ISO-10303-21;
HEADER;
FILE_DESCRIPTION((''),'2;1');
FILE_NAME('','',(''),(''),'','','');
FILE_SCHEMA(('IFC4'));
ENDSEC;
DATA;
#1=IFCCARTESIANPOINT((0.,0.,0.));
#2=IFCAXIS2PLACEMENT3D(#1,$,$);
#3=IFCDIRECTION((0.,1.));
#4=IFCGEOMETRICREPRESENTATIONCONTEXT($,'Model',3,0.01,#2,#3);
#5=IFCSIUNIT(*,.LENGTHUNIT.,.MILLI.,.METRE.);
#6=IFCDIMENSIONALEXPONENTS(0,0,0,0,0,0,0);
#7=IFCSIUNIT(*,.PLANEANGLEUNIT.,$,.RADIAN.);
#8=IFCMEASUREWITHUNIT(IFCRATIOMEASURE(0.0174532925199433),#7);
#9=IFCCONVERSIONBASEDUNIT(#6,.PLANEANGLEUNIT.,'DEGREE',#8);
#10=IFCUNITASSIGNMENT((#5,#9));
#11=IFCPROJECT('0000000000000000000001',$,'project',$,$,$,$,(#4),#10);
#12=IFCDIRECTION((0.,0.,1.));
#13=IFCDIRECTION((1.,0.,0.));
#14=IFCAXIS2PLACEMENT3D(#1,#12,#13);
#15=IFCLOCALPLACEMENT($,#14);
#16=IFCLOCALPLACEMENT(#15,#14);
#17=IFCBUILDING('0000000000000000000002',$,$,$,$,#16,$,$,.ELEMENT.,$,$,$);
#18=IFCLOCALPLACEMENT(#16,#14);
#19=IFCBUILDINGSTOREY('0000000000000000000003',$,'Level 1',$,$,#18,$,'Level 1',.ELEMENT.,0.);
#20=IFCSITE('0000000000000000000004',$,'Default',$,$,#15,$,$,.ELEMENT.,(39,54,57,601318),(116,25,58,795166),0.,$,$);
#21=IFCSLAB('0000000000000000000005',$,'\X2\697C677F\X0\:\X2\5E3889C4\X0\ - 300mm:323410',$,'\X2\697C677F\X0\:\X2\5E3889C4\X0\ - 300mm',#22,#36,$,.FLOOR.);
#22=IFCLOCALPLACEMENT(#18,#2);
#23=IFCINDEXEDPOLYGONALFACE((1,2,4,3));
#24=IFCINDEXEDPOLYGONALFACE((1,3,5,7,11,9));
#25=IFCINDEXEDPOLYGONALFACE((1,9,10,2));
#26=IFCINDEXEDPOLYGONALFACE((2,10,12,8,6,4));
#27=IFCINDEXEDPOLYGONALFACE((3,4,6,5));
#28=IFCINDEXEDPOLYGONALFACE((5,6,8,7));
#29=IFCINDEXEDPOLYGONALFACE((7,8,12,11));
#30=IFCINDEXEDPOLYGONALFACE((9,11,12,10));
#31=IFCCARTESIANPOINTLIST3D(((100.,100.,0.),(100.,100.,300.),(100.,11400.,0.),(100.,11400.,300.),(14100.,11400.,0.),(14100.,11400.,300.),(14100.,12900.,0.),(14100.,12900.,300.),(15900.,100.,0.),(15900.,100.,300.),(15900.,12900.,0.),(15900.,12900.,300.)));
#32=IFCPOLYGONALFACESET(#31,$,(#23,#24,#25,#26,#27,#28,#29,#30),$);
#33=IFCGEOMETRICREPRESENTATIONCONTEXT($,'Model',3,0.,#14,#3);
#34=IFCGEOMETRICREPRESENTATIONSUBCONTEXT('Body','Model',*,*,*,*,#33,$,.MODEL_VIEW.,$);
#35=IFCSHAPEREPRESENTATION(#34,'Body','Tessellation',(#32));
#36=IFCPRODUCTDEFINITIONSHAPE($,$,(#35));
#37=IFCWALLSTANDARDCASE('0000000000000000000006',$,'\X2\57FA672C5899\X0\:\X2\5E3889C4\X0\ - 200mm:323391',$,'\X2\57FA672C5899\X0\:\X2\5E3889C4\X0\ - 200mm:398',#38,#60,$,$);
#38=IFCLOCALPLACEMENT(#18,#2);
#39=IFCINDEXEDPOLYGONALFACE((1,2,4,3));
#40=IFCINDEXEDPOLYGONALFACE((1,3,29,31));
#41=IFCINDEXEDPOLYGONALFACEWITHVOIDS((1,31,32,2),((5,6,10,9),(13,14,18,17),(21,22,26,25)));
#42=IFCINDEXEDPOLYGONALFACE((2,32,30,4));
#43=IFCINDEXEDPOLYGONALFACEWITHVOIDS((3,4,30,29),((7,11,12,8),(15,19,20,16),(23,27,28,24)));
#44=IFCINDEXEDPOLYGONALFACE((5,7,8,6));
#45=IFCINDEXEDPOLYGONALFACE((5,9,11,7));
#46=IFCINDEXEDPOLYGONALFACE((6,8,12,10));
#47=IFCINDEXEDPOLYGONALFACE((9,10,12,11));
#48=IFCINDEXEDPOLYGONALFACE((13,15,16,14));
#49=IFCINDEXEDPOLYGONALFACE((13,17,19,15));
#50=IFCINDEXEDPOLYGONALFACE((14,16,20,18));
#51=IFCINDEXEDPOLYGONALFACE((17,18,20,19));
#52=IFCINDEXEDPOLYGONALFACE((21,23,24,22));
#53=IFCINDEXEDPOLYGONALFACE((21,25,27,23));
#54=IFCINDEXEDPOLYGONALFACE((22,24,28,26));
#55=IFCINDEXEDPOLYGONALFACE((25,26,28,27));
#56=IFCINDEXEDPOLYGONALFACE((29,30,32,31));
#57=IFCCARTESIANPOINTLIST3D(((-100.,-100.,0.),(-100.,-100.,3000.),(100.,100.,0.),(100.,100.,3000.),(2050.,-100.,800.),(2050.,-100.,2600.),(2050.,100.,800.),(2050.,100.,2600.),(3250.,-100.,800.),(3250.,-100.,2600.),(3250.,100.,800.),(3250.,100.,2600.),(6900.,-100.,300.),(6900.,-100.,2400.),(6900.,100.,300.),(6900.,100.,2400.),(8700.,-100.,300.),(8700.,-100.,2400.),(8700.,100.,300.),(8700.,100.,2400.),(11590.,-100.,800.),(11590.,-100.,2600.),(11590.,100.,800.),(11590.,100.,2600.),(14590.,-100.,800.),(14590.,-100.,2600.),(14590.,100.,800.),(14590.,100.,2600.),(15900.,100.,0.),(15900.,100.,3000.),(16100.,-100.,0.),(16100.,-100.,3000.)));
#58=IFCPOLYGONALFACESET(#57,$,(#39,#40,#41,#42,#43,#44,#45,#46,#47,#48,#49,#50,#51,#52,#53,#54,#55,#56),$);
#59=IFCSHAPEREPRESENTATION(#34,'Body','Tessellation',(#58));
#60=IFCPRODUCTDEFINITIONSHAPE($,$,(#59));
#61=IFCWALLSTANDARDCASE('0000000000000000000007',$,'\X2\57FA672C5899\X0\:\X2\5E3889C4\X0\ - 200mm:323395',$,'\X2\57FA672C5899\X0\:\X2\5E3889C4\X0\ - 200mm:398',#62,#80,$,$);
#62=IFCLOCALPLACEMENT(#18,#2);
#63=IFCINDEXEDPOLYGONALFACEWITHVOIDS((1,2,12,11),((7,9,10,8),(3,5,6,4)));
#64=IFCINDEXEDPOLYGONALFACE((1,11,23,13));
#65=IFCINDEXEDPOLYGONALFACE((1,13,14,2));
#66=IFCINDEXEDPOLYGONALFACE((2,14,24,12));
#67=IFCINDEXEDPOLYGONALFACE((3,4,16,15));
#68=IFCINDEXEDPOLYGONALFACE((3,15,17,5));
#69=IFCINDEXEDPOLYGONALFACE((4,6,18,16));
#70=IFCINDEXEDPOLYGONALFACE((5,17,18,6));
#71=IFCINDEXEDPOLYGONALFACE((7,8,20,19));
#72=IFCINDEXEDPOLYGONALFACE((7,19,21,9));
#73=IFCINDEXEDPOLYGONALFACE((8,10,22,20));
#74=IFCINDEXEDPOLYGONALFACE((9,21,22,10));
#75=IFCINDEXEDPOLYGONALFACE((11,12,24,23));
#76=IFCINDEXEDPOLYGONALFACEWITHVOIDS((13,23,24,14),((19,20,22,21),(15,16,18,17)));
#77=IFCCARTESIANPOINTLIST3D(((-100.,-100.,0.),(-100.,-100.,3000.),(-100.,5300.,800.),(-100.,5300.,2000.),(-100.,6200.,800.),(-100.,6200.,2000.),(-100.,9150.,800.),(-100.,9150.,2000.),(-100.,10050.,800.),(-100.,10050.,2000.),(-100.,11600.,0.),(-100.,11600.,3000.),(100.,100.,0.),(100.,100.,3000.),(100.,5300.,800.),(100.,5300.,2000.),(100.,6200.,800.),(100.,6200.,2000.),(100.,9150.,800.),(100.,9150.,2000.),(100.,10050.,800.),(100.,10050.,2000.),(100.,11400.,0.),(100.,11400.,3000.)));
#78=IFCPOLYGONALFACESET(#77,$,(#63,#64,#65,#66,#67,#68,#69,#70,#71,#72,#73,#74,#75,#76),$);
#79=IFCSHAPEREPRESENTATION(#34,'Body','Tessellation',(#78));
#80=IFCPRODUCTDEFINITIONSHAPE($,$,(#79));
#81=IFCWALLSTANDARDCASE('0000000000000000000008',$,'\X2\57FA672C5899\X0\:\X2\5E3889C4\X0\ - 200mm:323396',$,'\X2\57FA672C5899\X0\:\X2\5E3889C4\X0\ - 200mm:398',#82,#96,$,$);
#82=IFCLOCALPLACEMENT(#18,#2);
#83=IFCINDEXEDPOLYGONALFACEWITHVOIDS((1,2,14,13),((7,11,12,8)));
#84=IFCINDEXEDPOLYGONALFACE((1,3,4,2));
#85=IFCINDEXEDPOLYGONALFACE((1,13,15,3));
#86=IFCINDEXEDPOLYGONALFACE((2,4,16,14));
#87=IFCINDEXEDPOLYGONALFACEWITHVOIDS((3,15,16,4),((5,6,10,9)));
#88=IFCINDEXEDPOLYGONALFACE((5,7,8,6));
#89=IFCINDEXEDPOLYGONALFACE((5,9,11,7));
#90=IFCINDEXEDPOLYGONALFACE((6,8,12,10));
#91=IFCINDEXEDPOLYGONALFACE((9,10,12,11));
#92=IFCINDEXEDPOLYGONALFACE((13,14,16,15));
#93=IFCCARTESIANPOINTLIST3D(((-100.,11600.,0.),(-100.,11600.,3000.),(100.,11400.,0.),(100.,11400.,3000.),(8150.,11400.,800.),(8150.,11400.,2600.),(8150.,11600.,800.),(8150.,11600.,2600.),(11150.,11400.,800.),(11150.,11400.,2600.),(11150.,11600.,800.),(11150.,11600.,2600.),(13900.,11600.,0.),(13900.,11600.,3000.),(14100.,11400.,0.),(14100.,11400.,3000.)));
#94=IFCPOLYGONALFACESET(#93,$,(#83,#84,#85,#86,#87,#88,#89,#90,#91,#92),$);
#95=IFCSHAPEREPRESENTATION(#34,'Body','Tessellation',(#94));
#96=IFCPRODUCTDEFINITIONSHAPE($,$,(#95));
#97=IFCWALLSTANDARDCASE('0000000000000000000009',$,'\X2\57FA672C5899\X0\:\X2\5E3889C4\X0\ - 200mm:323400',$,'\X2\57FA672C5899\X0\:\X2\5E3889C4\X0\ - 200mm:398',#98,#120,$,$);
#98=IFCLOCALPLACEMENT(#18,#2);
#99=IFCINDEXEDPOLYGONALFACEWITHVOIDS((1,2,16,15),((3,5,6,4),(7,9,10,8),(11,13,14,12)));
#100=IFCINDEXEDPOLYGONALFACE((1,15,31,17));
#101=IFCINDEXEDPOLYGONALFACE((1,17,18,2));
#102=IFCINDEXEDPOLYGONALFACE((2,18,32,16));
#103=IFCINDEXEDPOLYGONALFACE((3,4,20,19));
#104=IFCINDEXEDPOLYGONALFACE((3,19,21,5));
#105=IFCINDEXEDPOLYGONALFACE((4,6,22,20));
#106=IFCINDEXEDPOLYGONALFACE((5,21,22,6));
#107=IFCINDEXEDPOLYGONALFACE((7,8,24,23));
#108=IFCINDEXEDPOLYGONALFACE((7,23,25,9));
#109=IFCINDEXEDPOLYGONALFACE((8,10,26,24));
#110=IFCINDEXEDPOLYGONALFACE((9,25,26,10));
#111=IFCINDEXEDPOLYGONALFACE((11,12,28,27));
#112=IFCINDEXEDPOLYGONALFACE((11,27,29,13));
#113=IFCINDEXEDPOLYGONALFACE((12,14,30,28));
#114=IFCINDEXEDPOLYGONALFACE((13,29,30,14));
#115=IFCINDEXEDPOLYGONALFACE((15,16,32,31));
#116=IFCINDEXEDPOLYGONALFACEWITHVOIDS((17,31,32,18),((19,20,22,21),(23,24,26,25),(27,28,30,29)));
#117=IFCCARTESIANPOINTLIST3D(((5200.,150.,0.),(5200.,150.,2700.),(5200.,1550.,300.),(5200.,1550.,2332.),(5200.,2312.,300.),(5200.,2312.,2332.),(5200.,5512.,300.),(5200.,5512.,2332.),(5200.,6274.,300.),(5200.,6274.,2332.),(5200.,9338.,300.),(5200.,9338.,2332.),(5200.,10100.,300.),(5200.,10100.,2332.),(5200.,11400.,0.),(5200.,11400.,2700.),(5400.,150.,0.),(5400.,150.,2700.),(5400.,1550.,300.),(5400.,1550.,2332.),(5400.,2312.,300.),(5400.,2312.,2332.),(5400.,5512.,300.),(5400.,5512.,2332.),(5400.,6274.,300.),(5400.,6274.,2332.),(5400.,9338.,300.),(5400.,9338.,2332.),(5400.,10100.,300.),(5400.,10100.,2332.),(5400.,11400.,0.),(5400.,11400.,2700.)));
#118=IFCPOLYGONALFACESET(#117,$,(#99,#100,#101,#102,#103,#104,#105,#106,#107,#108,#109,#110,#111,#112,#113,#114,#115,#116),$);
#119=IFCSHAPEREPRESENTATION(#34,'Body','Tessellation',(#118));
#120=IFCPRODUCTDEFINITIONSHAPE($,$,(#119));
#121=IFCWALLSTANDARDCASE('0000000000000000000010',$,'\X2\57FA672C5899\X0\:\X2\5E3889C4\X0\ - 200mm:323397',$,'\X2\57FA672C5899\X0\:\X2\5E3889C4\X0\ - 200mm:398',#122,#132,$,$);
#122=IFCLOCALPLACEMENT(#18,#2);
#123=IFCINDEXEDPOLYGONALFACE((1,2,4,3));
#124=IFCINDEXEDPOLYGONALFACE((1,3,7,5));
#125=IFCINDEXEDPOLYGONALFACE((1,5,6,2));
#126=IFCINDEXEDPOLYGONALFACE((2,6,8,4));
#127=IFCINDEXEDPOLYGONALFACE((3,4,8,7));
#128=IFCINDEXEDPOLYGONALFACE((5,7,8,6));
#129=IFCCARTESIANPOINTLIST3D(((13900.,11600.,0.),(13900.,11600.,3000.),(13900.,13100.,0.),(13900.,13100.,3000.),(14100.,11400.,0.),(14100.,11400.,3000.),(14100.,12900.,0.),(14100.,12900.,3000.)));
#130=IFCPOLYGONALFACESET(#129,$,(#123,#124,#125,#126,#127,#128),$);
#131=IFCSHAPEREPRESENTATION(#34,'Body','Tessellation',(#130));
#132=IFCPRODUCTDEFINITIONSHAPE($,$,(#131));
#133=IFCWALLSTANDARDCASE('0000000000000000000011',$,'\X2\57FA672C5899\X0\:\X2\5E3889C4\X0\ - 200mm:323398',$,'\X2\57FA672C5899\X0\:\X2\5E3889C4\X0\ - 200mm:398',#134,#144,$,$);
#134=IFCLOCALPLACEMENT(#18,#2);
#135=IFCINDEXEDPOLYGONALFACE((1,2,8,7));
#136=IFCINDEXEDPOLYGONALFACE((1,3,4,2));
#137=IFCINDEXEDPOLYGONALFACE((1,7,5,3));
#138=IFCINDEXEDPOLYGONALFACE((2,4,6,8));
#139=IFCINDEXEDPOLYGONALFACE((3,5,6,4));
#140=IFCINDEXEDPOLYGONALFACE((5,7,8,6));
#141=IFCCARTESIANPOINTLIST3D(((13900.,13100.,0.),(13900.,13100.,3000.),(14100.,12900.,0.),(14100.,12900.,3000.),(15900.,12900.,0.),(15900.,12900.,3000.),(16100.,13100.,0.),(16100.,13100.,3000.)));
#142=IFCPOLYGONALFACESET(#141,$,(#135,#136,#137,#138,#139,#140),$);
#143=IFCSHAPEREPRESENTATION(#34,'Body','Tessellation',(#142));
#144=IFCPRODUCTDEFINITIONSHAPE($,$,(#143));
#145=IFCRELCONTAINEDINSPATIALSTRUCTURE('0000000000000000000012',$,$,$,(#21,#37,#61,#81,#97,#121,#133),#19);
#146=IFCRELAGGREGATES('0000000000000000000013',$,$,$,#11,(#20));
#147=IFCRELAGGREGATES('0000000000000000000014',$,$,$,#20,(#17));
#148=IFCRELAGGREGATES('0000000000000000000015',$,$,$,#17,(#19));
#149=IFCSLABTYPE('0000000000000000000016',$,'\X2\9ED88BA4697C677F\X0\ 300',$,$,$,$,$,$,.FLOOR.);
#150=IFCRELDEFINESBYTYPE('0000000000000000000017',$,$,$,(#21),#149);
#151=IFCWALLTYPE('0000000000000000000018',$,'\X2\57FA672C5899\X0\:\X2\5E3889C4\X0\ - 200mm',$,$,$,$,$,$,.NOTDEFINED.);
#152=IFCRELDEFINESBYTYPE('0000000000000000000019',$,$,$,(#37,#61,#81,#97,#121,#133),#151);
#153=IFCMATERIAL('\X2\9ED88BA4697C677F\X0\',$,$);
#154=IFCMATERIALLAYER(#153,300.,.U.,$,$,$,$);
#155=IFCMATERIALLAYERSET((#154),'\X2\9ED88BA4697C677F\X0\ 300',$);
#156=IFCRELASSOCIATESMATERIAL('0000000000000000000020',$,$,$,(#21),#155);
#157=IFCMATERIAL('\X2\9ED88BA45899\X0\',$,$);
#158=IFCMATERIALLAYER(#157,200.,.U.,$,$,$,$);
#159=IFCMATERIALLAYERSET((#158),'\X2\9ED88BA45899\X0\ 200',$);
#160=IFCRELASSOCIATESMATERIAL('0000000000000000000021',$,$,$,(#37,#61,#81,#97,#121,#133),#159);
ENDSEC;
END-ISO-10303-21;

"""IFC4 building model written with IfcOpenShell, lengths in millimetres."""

from ifc_helpers import new_model, entity, si_unit, converted_unit, direction, frame, origin, origin_with_axes, place, context, subcontext, project, spatial, polyline, outline, extrude, clip, halfspace, material, layer, layer_set, layer_usage, type_object, element, save


model = new_model("IFC4")

# Units and contexts
model_context_1 = context("Model", 3, precision=0.01, world=origin(), true_north=direction((0.0, 1.0)))
model_context_2 = context("Model", 3, precision=0.0, world=origin_with_axes(), true_north=direction((0.0, 1.0)))
body_context = subcontext(model_context_2, "Body", "Model", "MODEL_VIEW")
ifc_project = project(units=[si_unit("LENGTHUNIT", "METRE", prefix="MILLI"), converted_unit("PLANEANGLEUNIT", "DEGREE", entity("IfcRatioMeasure", 0.0174532925199433), si_unit("PLANEANGLEUNIT", "RADIAN"), dimensions=[0, 0, 0, 0, 0, 0, 0])], contexts=[model_context_1])

# Site, building, storey
site_placement = place(None, origin_with_axes())
site = spatial("IfcSite", under=ifc_project, at=site_placement, Name="Default", CompositionType="ELEMENT", RefLatitude=(39, 54, 57, 601318), RefLongitude=(116, 25, 58, 795166), RefElevation=0.0)
building_placement = place(site_placement, origin_with_axes())
building = spatial("IfcBuilding", under=site, at=building_placement, CompositionType="ELEMENT")
storey_placement = place(building_placement, origin_with_axes())
storey = spatial("IfcBuildingStorey", under=building, at=storey_placement, Name="Level 1", LongName="Level 1", CompositionType="ELEMENT", Elevation=0.0)

# Slab
ifc_material_1 = material(Name="默认楼板")
ifc_layer_1 = layer(ifc_material_1, 300.0, ventilated="UNKNOWN")
ifc_layer_set_1 = layer_set([ifc_layer_1], Name="默认楼板 300")
ifc_layer_usage_1 = layer_usage(ifc_layer_set_1, "AXIS3", "NEGATIVE", 300.0)
slab_type = type_object("IfcSlabType", Name="默认楼板 300", PredefinedType="FLOOR")
slab_placement = place(storey_placement, frame((100.0, 100.0, 0.0), z_axis=(0.0, 0.0, 1.0), x_axis=(1.0, 0.0, 0.0)))
element("IfcSlab", 1, at=slab_placement, inside=storey, type_object=slab_type, material=ifc_layer_usage_1, Name="楼板:常规 - 300mm:323410", ObjectType="楼板:常规 - 300mm", PredefinedType="FLOOR", context=body_context, shape_type="SweptSolid", body=[
    extrude(outline(polyline([(0.0, 0.0), (15800.0, 0.0), (15800.0, 12800.0), (14000.0, 12800.0), (14000.0, 11300.0), (0.0, 11300.0), (0.0, 0.0)])), origin_with_axes(), (0.0, 0.0, 1.0), 300.0),
])

# Walls, openings
ifc_material_2 = material(Name="默认墙")
ifc_layer_2 = layer(ifc_material_2, 200.0, ventilated="UNKNOWN")
ifc_layer_set_2 = layer_set([ifc_layer_2], Name="默认墙 200")
ifc_layer_usage_2 = layer_usage(ifc_layer_set_2, "AXIS2", "POSITIVE", -100.0)
wall_type = type_object("IfcWallType", Name="基本墙:常规 - 200mm", PredefinedType="NOTDEFINED")
wall_1_placement = place(storey_placement, frame((16000.0, 0.0, 0.0), z_axis=(0.0, 0.0, 1.0), x_axis=(-1.0, 0.0, 0.0)))
wall_1 = element("IfcWallStandardCase", 2, at=wall_1_placement, inside=storey, type_object=wall_type, material=ifc_layer_usage_2, Name="基本墙:常规 - 200mm:323391", ObjectType="基本墙:常规 - 200mm:398", context=body_context, shape_type="SweptSolid", body=[
    extrude(outline(polyline([(100.0, -100.0), (15900.0, -100.0), (16100.0, 100.0), (-100.0, 100.0), (100.0, -100.0)])), origin_with_axes(), (0.0, 0.0, 1.0), 3000.0),
])
opening_1_placement = place(wall_1_placement, frame((13350.0, 0.0, 800.0), z_axis=(0.0, 0.0, 1.0), x_axis=(1.0, 0.0, 0.0)))
element("IfcOpeningElement", 3, at=opening_1_placement, cuts=wall_1, context=body_context, shape_type="SweptSolid", body=[
    extrude(outline(polyline([(-600.0, 0.0), (-600.0, -1800.0), (600.0, -1800.0), (600.0, 0.0), (-600.0, 0.0)])), frame((0.0, -100.0, 0.0), z_axis=(0.0, 1.0, 0.0), x_axis=(1.0, 0.0, 0.0)), (0.0, 0.0, 1.0), 200.0),
])
opening_2_placement = place(wall_1_placement, frame((2910.0, 0.0, 800.0), z_axis=(0.0, 0.0, 1.0), x_axis=(1.0, 0.0, 0.0)))
element("IfcOpeningElement", 4, at=opening_2_placement, cuts=wall_1, context=body_context, shape_type="SweptSolid", body=[
    extrude(outline(polyline([(-1500.0, 0.0), (-1500.0, -1800.0), (1500.0, -1800.0), (1500.0, 0.0), (-1500.0, 0.0)])), frame((0.0, -100.0, 0.0), z_axis=(0.0, 1.0, 0.0), x_axis=(1.0, 0.0, 0.0)), (0.0, 0.0, 1.0), 200.0),
])
opening_3_placement = place(wall_1_placement, frame((8200.0, 0.0, 300.0), z_axis=(0.0, 0.0, 1.0), x_axis=(1.0, 0.0, 0.0)))
element("IfcOpeningElement", 5, at=opening_3_placement, cuts=wall_1, context=body_context, shape_type="SweptSolid", body=[
    extrude(outline(polyline([(-900.0, 0.0), (-900.0, -2100.0), (900.0, -2100.0), (900.0, 0.0), (-900.0, 0.0)])), frame((0.0, -100.0, 0.0), z_axis=(0.0, 1.0, 0.0), x_axis=(1.0, 0.0, 0.0)), (0.0, 0.0, 1.0), 200.0),
])
ifc_layer_usage_3 = layer_usage(ifc_layer_set_2, "AXIS2", "POSITIVE", -100.0)
wall_2_placement = place(storey_placement, frame((0.0, 0.0, 0.0), z_axis=(0.0, 0.0, 1.0), x_axis=(0.0, 1.0, 0.0)))
wall_2 = element("IfcWallStandardCase", 6, at=wall_2_placement, inside=storey, type_object=wall_type, material=ifc_layer_usage_3, Name="基本墙:常规 - 200mm:323395", ObjectType="基本墙:常规 - 200mm:398", context=body_context, shape_type="SweptSolid", body=[
    extrude(outline(polyline([(100.0, -100.0), (11400.0, -100.0), (11600.0, 100.0), (-100.0, 100.0), (100.0, -100.0)])), origin_with_axes(), (0.0, 0.0, 1.0), 3000.0),
])
opening_4_placement = place(wall_2_placement, frame((5750.0, 0.0, 800.0), z_axis=(0.0, 0.0, 1.0), x_axis=(1.0, 0.0, 0.0)))
element("IfcOpeningElement", 7, at=opening_4_placement, cuts=wall_2, context=body_context, shape_type="SweptSolid", body=[
    extrude(outline(polyline([(450.0, -1200.0), (450.0, 0.0), (-450.0, 0.0), (-450.0, -1200.0), (450.0, -1200.0)])), frame((0.0, 100.0, 0.0), z_axis=(0.0, -1.0, 0.0), x_axis=(-1.0, 0.0, 0.0)), (0.0, 0.0, 1.0), 200.0),
])
opening_5_placement = place(wall_2_placement, frame((9600.0, 0.0, 800.0), z_axis=(0.0, 0.0, 1.0), x_axis=(1.0, 0.0, 0.0)))
element("IfcOpeningElement", 8, at=opening_5_placement, cuts=wall_2, context=body_context, shape_type="SweptSolid", body=[
    extrude(outline(polyline([(450.0, -1200.0), (450.0, 0.0), (-450.0, 0.0), (-450.0, -1200.0), (450.0, -1200.0)])), frame((0.0, 100.0, 0.0), z_axis=(0.0, -1.0, 0.0), x_axis=(-1.0, 0.0, 0.0)), (0.0, 0.0, 1.0), 200.0),
])

# Wall, opening
ifc_layer_usage_4 = layer_usage(ifc_layer_set_2, "AXIS2", "POSITIVE", -100.0)
wall_3_placement = place(storey_placement, frame((0.0, 11500.0, 0.0), z_axis=(0.0, 0.0, 1.0), x_axis=(1.0, 0.0, 0.0)))
wall_3 = element("IfcWallStandardCase", 9, at=wall_3_placement, inside=storey, type_object=wall_type, material=ifc_layer_usage_4, Name="基本墙:常规 - 200mm:323396", ObjectType="基本墙:常规 - 200mm:398", context=body_context, shape_type="SweptSolid", body=[
    extrude(outline(polyline([(100.0, -100.0), (14100.0, -100.0), (13900.0, 100.0), (-100.0, 100.0), (100.0, -100.0)])), origin_with_axes(), (0.0, 0.0, 1.0), 3000.0),
])
opening_6_placement = place(wall_3_placement, frame((9650.0, 0.0, 800.0), z_axis=(0.0, 0.0, 1.0), x_axis=(1.0, 0.0, 0.0)))
element("IfcOpeningElement", 10, at=opening_6_placement, cuts=wall_3, context=body_context, shape_type="SweptSolid", body=[
    extrude(outline(polyline([(-1500.0, 0.0), (-1500.0, -1800.0), (1500.0, -1800.0), (1500.0, 0.0), (-1500.0, 0.0)])), frame((0.0, -100.0, 0.0), z_axis=(0.0, 1.0, 0.0), x_axis=(1.0, 0.0, 0.0)), (0.0, 0.0, 1.0), 200.0),
])

# Wall, openings
ifc_layer_usage_5 = layer_usage(ifc_layer_set_2, "AXIS2", "POSITIVE", -100.0)
wall_4_placement = place(storey_placement, frame((5300.0, 11500.0, 0.0), z_axis=(0.0, 0.0, 1.0), x_axis=(0.0, -1.0, 0.0)))
wall_4 = element("IfcWallStandardCase", 11, at=wall_4_placement, inside=storey, type_object=wall_type, material=ifc_layer_usage_5, Name="基本墙:常规 - 200mm:323400", ObjectType="基本墙:常规 - 200mm:398", context=body_context, shape_type="Clipping", body=[
    clip(extrude(outline(polyline([(100.0, -100.0), (11350.0, -100.0), (11350.0, 100.0), (100.0, 100.0), (100.0, -100.0)])), origin_with_axes(), (0.0, 0.0, 1.0), 2700.0), halfspace(frame((0.0, 0.0, 2700.0), z_axis=(0.0, 0.0, -1.0), x_axis=(0.0, 1.0, 0.0)), True)),
])
opening_7_placement = place(wall_4_placement, frame((9569.0, 0.0, 300.0), z_axis=(0.0, 0.0, 1.0), x_axis=(1.0, 0.0, 0.0)))
element("IfcOpeningElement", 12, at=opening_7_placement, cuts=wall_4, context=body_context, shape_type="SweptSolid", body=[
    extrude(outline(polyline([(-381.0, -2032.0), (381.0, -2032.0), (381.0, 0.0), (-381.0, 0.0), (-381.0, -2032.0)])), frame((0.0, -100.0, 0.0), z_axis=(0.0, 1.0, 0.0), x_axis=(1.0, 0.0, 0.0)), (0.0, 0.0, 1.0), 200.0),
])
opening_8_placement = place(wall_4_placement, frame((5607.0, 0.0, 300.0), z_axis=(0.0, 0.0, 1.0), x_axis=(1.0, 0.0, 0.0)))
element("IfcOpeningElement", 13, at=opening_8_placement, cuts=wall_4, context=body_context, shape_type="SweptSolid", body=[
    extrude(outline(polyline([(-381.0, -2032.0), (381.0, -2032.0), (381.0, 0.0), (-381.0, 0.0), (-381.0, -2032.0)])), frame((0.0, -100.0, 0.0), z_axis=(0.0, 1.0, 0.0), x_axis=(1.0, 0.0, 0.0)), (0.0, 0.0, 1.0), 200.0),
])
opening_9_placement = place(wall_4_placement, frame((1781.0, 0.0, 300.0), z_axis=(0.0, 0.0, 1.0), x_axis=(1.0, 0.0, 0.0)))
element("IfcOpeningElement", 14, at=opening_9_placement, cuts=wall_4, context=body_context, shape_type="SweptSolid", body=[
    extrude(outline(polyline([(-381.0, -2032.0), (381.0, -2032.0), (381.0, 0.0), (-381.0, 0.0), (-381.0, -2032.0)])), frame((0.0, -100.0, 0.0), z_axis=(0.0, 1.0, 0.0), x_axis=(1.0, 0.0, 0.0)), (0.0, 0.0, 1.0), 200.0),
])

# Walls
ifc_layer_usage_6 = layer_usage(ifc_layer_set_2, "AXIS2", "POSITIVE", -100.0)
wall_5_placement = place(storey_placement, frame((14000.0, 11500.0, 0.0), z_axis=(0.0, 0.0, 1.0), x_axis=(0.0, 1.0, 0.0)))
element("IfcWallStandardCase", 15, at=wall_5_placement, inside=storey, type_object=wall_type, material=ifc_layer_usage_6, Name="基本墙:常规 - 200mm:323397", ObjectType="基本墙:常规 - 200mm:398", context=body_context, shape_type="SweptSolid", body=[
    extrude(outline(polyline([(-100.0, -100.0), (1400.0, -100.0), (1600.0, 100.0), (100.0, 100.0), (-100.0, -100.0)])), origin_with_axes(), (0.0, 0.0, 1.0), 3000.0),
])
ifc_layer_usage_7 = layer_usage(ifc_layer_set_2, "AXIS2", "POSITIVE", -100.0)
wall_6_placement = place(storey_placement, frame((14000.0, 13000.0, 0.0), z_axis=(0.0, 0.0, 1.0), x_axis=(1.0, 0.0, 0.0)))
element("IfcWallStandardCase", 16, at=wall_6_placement, inside=storey, type_object=wall_type, material=ifc_layer_usage_7, Name="基本墙:常规 - 200mm:323398", ObjectType="基本墙:常规 - 200mm:398", context=body_context, shape_type="SweptSolid", body=[
    extrude(outline(polyline([(100.0, -100.0), (1900.0, -100.0), (2100.0, 100.0), (-100.0, 100.0), (100.0, -100.0)])), origin_with_axes(), (0.0, 0.0, 1.0), 3000.0),
])

save(model, "model.ifc")
